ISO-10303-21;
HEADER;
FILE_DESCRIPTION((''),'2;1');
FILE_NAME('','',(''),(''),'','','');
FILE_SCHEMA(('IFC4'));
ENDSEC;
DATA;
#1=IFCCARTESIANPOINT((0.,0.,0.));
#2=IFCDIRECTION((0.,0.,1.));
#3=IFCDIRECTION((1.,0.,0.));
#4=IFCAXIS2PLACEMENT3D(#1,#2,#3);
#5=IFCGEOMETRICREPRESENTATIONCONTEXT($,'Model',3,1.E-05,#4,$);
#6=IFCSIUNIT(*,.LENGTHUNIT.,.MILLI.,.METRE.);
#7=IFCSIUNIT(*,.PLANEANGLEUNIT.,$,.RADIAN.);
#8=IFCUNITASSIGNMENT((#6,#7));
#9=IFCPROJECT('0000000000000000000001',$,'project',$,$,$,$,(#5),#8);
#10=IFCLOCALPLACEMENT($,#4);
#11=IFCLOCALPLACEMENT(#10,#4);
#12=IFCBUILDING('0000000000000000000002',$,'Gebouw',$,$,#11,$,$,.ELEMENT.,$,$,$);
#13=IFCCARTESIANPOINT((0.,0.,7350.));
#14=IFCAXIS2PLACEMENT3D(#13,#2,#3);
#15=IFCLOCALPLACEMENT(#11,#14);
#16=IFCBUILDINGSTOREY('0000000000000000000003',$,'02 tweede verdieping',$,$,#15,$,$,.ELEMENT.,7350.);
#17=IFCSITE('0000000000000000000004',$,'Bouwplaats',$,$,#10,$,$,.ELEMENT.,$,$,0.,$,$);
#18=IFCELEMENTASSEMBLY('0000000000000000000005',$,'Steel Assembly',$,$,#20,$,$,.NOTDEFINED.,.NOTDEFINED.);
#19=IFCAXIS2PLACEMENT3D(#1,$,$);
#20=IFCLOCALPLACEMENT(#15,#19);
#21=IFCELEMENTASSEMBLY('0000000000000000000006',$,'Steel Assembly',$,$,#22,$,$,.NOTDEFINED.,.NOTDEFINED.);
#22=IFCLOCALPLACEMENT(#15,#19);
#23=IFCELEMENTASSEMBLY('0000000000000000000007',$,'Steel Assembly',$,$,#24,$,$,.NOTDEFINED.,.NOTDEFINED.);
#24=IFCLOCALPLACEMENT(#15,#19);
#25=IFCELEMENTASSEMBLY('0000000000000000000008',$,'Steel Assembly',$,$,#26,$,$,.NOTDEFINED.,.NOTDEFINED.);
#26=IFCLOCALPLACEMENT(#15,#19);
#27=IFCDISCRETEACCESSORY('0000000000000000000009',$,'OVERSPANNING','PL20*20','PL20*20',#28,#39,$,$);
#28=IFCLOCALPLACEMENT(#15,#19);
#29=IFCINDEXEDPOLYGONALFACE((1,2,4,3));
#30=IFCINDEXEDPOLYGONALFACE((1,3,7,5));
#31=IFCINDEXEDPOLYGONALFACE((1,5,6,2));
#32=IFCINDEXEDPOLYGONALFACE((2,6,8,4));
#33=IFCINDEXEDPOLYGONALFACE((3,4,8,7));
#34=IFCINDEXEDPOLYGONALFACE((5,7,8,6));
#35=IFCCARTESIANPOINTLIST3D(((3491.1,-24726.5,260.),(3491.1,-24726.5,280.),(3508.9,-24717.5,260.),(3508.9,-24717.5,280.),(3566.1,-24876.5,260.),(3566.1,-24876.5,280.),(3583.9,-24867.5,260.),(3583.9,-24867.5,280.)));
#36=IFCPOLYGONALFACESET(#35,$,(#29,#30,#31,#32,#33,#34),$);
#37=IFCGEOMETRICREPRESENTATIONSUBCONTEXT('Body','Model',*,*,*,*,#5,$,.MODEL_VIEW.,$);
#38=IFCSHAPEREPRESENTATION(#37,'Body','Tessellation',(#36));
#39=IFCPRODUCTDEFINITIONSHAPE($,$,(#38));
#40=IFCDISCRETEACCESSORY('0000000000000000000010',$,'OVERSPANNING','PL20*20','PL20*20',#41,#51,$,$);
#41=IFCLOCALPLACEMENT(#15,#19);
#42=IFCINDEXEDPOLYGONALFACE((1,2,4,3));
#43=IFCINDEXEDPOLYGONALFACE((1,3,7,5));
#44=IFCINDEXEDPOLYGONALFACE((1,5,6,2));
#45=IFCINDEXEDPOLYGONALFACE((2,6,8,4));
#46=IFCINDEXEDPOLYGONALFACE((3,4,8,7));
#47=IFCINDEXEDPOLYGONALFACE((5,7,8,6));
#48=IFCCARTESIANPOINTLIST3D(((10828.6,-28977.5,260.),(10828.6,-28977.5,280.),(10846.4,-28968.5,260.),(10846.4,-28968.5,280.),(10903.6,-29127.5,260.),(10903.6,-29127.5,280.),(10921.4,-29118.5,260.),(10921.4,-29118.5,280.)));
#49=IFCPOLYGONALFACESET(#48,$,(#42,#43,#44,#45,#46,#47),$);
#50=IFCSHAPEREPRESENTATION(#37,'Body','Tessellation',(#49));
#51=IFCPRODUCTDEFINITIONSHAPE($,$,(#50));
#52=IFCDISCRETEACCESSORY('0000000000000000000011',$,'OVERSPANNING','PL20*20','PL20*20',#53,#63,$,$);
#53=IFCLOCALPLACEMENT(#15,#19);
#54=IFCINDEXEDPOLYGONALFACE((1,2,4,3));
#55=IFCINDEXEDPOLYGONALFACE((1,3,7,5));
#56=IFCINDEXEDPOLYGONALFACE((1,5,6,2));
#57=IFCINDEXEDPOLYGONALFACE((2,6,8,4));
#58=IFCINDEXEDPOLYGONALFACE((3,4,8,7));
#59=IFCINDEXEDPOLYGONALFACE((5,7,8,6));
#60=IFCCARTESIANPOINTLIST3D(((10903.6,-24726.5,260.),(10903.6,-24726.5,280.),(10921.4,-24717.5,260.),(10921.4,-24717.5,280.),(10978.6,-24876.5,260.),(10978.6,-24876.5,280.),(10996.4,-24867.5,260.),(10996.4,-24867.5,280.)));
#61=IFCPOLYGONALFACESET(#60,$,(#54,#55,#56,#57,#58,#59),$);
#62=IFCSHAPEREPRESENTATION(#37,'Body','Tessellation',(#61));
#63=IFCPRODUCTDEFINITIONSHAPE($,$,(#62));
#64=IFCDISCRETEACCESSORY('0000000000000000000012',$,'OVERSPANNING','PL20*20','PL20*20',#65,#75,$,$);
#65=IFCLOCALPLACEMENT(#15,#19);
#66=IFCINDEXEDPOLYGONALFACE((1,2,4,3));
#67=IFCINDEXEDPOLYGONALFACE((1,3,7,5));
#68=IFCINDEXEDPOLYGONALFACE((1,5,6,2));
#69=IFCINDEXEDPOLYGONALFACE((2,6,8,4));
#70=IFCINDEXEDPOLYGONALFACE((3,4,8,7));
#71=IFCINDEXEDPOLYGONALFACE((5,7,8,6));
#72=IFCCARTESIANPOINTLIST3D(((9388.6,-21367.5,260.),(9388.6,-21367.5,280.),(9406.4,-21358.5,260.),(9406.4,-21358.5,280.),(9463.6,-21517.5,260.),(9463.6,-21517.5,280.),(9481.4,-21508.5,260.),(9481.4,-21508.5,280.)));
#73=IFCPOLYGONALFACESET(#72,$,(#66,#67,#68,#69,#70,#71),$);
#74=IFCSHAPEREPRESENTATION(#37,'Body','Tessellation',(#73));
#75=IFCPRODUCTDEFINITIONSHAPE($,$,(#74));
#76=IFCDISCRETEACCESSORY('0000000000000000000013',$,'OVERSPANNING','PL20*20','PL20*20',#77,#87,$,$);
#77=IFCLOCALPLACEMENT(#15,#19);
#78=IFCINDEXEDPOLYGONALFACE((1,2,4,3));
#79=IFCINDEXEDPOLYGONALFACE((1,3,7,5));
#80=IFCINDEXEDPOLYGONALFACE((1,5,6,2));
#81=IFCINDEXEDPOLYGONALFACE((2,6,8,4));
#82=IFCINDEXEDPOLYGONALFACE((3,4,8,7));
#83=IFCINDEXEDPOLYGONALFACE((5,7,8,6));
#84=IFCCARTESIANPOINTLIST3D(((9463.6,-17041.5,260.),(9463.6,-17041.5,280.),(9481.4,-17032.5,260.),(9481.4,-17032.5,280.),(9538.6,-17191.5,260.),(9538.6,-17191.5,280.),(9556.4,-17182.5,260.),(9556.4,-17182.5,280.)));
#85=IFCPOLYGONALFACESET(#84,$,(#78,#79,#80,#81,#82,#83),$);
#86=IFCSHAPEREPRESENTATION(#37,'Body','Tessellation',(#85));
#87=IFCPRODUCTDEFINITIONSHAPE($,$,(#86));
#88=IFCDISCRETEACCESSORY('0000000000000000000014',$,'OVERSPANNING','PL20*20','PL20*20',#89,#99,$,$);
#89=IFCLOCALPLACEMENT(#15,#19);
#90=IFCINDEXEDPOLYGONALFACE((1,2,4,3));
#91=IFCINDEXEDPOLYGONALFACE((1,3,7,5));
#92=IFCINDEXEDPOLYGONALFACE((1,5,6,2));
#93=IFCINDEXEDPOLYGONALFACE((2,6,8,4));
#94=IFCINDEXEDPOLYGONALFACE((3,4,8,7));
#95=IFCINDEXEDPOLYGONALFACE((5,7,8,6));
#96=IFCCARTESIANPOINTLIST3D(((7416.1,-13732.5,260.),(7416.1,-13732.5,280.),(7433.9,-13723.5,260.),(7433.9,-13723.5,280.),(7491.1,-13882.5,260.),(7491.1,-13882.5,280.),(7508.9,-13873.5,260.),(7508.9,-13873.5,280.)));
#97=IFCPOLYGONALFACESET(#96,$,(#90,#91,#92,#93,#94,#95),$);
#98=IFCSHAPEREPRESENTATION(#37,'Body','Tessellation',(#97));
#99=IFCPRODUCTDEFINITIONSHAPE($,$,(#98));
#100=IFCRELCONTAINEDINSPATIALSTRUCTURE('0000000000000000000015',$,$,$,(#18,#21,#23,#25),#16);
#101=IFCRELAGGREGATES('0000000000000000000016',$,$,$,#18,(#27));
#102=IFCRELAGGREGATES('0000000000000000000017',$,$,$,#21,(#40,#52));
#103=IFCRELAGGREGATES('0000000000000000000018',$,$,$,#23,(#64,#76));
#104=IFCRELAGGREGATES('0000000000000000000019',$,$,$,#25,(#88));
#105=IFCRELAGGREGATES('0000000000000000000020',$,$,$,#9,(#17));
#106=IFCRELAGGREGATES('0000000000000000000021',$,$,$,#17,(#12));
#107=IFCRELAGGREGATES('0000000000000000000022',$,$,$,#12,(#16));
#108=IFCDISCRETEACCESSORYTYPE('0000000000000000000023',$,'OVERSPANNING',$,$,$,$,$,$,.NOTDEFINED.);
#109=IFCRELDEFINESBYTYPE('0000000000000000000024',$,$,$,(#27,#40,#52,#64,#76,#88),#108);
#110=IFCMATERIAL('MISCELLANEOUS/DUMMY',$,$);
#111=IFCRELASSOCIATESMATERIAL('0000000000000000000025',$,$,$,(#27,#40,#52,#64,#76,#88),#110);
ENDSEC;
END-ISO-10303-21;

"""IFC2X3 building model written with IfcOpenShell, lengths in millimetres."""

from ifc_helpers import new_model, si_unit, frame, origin_with_axes, origin_2d_with_axis, place, context, subcontext, project, spatial, rectangle, extrude, material, type_object, element, aggregate, save


model = new_model("IFC2X3")

# Units and contexts
model_context = context("Model", 3, precision=1e-05, world=origin_with_axes())
body_context = subcontext(model_context, "Body", "Model", "MODEL_VIEW")
ifc_project = project(units=[si_unit("LENGTHUNIT", "METRE", prefix="MILLI"), si_unit("PLANEANGLEUNIT", "RADIAN")], contexts=[model_context])

# Site, building, storey
site_placement = place(None, origin_with_axes())
site = spatial("IfcSite", under=ifc_project, at=site_placement, Name="Bouwplaats", CompositionType="ELEMENT", RefElevation=0.0)
building_placement = place(site_placement, origin_with_axes())
building = spatial("IfcBuilding", under=site, at=building_placement, Name="Gebouw", CompositionType="ELEMENT")
storey_placement = place(building_placement, frame((0.0, 0.0, 7350.0), z_axis=(0.0, 0.0, 1.0), x_axis=(1.0, 0.0, 0.0)))
storey = spatial("IfcBuildingStorey", under=building, at=storey_placement, Name="02 tweede verdieping", CompositionType="ELEMENT", Elevation=7350.0)

# Element assemblies
ifc_material_1 = material(Name="MISCELLANEOUS/DUMMY")
assembly_1_placement = place(storey_placement, origin_with_axes())
assembly_1 = element("IfcElementAssembly", 1, at=assembly_1_placement, inside=storey, Name="Steel Assembly", AssemblyPlace="NOTDEFINED", PredefinedType="NOTDEFINED")
assembly_2_placement = place(storey_placement, origin_with_axes())
assembly_2 = element("IfcElementAssembly", 2, at=assembly_2_placement, inside=storey, Name="Steel Assembly", AssemblyPlace="NOTDEFINED", PredefinedType="NOTDEFINED")
assembly_3_placement = place(storey_placement, origin_with_axes())
assembly_3 = element("IfcElementAssembly", 3, at=assembly_3_placement, inside=storey, Name="Steel Assembly", AssemblyPlace="NOTDEFINED", PredefinedType="NOTDEFINED")
assembly_4_placement = place(storey_placement, origin_with_axes())
assembly_4 = element("IfcElementAssembly", 4, at=assembly_4_placement, inside=storey, Name="Steel Assembly", AssemblyPlace="NOTDEFINED", PredefinedType="NOTDEFINED")

# Discrete accessories
discrete_accessory_type = type_object("IfcDiscreteAccessoryType", Name="OVERSPANNING")
discrete_accessory_1_placement = place(assembly_1_placement, frame((3575.0, -24872.0, 270.0), z_axis=(-0.894427, -0.447214, 0.0), x_axis=(-0.447214, 0.894427, 0.0)))
discrete_accessory_1 = element("IfcDiscreteAccessory", 5, at=discrete_accessory_1_placement, type_object=discrete_accessory_type, material=ifc_material_1, Name="OVERSPANNING", Description="PL20*20", ObjectType="PL20*20", context=body_context, shape_type="SweptSolid", body=[
    extrude(rectangle(XDim=20.0, YDim=20.0, at=origin_2d_with_axis()), frame((167.7, 0.0, 0.0), z_axis=(-1.0, 0.0, 0.0), x_axis=(0.0, -1.0, 0.0)), (0.0, 0.0, 1.0), 167.7),
])
aggregate(assembly_1, [discrete_accessory_1])
discrete_accessory_2_placement = place(assembly_2_placement, frame((10837.5, -28973.0, 270.0), z_axis=(0.894427, 0.447214, 0.0), x_axis=(0.447214, -0.894427, 0.0)))
discrete_accessory_2 = element("IfcDiscreteAccessory", 6, at=discrete_accessory_2_placement, type_object=discrete_accessory_type, material=ifc_material_1, Name="OVERSPANNING", Description="PL20*20", ObjectType="PL20*20", context=body_context, shape_type="SweptSolid", body=[
    extrude(rectangle(XDim=20.0, YDim=20.0, at=origin_2d_with_axis()), frame((167.7, 0.0, 0.0), z_axis=(-1.0, 0.0, 0.0), x_axis=(0.0, -1.0, 0.0)), (0.0, 0.0, 1.0), 167.7),
])
discrete_accessory_3_placement = place(assembly_2_placement, frame((10987.5, -24872.0, 270.0), z_axis=(-0.894427, -0.447214, 0.0), x_axis=(-0.447214, 0.894427, 0.0)))
discrete_accessory_3 = element("IfcDiscreteAccessory", 7, at=discrete_accessory_3_placement, type_object=discrete_accessory_type, material=ifc_material_1, Name="OVERSPANNING", Description="PL20*20", ObjectType="PL20*20", context=body_context, shape_type="SweptSolid", body=[
    extrude(rectangle(XDim=20.0, YDim=20.0, at=origin_2d_with_axis()), frame((167.7, 0.0, 0.0), z_axis=(-1.0, 0.0, 0.0), x_axis=(0.0, -1.0, 0.0)), (0.0, 0.0, 1.0), 167.7),
])
aggregate(assembly_2, [discrete_accessory_2, discrete_accessory_3])
discrete_accessory_4_placement = place(assembly_3_placement, frame((9397.5, -21363.0, 270.0), z_axis=(0.894427, 0.447214, 0.0), x_axis=(0.447214, -0.894427, 0.0)))
discrete_accessory_4 = element("IfcDiscreteAccessory", 8, at=discrete_accessory_4_placement, type_object=discrete_accessory_type, material=ifc_material_1, Name="OVERSPANNING", Description="PL20*20", ObjectType="PL20*20", context=body_context, shape_type="SweptSolid", body=[
    extrude(rectangle(XDim=20.0, YDim=20.0, at=origin_2d_with_axis()), frame((167.7, 0.0, 0.0), z_axis=(-1.0, 0.0, 0.0), x_axis=(0.0, -1.0, 0.0)), (0.0, 0.0, 1.0), 167.7),
])
discrete_accessory_5_placement = place(assembly_3_placement, frame((9547.5, -17187.0, 270.0), z_axis=(-0.894427, -0.447214, 0.0), x_axis=(-0.447214, 0.894427, 0.0)))
discrete_accessory_5 = element("IfcDiscreteAccessory", 9, at=discrete_accessory_5_placement, type_object=discrete_accessory_type, material=ifc_material_1, Name="OVERSPANNING", Description="PL20*20", ObjectType="PL20*20", context=body_context, shape_type="SweptSolid", body=[
    extrude(rectangle(XDim=20.0, YDim=20.0, at=origin_2d_with_axis()), frame((167.7, 0.0, 0.0), z_axis=(-1.0, 0.0, 0.0), x_axis=(0.0, -1.0, 0.0)), (0.0, 0.0, 1.0), 167.7),
])
aggregate(assembly_3, [discrete_accessory_4, discrete_accessory_5])
discrete_accessory_6_placement = place(assembly_4_placement, frame((7425.0, -13728.0, 270.0), z_axis=(0.894427, 0.447214, 0.0), x_axis=(0.447214, -0.894427, 0.0)))
discrete_accessory_6 = element("IfcDiscreteAccessory", 10, at=discrete_accessory_6_placement, type_object=discrete_accessory_type, material=ifc_material_1, Name="OVERSPANNING", Description="PL20*20", ObjectType="PL20*20", context=body_context, shape_type="SweptSolid", body=[
    extrude(rectangle(XDim=20.0, YDim=20.0, at=origin_2d_with_axis()), frame((167.7, 0.0, 0.0), z_axis=(-1.0, 0.0, 0.0), x_axis=(0.0, -1.0, 0.0)), (0.0, 0.0, 1.0), 167.7),
])
aggregate(assembly_4, [discrete_accessory_6])

save(model, "model.ifc")
